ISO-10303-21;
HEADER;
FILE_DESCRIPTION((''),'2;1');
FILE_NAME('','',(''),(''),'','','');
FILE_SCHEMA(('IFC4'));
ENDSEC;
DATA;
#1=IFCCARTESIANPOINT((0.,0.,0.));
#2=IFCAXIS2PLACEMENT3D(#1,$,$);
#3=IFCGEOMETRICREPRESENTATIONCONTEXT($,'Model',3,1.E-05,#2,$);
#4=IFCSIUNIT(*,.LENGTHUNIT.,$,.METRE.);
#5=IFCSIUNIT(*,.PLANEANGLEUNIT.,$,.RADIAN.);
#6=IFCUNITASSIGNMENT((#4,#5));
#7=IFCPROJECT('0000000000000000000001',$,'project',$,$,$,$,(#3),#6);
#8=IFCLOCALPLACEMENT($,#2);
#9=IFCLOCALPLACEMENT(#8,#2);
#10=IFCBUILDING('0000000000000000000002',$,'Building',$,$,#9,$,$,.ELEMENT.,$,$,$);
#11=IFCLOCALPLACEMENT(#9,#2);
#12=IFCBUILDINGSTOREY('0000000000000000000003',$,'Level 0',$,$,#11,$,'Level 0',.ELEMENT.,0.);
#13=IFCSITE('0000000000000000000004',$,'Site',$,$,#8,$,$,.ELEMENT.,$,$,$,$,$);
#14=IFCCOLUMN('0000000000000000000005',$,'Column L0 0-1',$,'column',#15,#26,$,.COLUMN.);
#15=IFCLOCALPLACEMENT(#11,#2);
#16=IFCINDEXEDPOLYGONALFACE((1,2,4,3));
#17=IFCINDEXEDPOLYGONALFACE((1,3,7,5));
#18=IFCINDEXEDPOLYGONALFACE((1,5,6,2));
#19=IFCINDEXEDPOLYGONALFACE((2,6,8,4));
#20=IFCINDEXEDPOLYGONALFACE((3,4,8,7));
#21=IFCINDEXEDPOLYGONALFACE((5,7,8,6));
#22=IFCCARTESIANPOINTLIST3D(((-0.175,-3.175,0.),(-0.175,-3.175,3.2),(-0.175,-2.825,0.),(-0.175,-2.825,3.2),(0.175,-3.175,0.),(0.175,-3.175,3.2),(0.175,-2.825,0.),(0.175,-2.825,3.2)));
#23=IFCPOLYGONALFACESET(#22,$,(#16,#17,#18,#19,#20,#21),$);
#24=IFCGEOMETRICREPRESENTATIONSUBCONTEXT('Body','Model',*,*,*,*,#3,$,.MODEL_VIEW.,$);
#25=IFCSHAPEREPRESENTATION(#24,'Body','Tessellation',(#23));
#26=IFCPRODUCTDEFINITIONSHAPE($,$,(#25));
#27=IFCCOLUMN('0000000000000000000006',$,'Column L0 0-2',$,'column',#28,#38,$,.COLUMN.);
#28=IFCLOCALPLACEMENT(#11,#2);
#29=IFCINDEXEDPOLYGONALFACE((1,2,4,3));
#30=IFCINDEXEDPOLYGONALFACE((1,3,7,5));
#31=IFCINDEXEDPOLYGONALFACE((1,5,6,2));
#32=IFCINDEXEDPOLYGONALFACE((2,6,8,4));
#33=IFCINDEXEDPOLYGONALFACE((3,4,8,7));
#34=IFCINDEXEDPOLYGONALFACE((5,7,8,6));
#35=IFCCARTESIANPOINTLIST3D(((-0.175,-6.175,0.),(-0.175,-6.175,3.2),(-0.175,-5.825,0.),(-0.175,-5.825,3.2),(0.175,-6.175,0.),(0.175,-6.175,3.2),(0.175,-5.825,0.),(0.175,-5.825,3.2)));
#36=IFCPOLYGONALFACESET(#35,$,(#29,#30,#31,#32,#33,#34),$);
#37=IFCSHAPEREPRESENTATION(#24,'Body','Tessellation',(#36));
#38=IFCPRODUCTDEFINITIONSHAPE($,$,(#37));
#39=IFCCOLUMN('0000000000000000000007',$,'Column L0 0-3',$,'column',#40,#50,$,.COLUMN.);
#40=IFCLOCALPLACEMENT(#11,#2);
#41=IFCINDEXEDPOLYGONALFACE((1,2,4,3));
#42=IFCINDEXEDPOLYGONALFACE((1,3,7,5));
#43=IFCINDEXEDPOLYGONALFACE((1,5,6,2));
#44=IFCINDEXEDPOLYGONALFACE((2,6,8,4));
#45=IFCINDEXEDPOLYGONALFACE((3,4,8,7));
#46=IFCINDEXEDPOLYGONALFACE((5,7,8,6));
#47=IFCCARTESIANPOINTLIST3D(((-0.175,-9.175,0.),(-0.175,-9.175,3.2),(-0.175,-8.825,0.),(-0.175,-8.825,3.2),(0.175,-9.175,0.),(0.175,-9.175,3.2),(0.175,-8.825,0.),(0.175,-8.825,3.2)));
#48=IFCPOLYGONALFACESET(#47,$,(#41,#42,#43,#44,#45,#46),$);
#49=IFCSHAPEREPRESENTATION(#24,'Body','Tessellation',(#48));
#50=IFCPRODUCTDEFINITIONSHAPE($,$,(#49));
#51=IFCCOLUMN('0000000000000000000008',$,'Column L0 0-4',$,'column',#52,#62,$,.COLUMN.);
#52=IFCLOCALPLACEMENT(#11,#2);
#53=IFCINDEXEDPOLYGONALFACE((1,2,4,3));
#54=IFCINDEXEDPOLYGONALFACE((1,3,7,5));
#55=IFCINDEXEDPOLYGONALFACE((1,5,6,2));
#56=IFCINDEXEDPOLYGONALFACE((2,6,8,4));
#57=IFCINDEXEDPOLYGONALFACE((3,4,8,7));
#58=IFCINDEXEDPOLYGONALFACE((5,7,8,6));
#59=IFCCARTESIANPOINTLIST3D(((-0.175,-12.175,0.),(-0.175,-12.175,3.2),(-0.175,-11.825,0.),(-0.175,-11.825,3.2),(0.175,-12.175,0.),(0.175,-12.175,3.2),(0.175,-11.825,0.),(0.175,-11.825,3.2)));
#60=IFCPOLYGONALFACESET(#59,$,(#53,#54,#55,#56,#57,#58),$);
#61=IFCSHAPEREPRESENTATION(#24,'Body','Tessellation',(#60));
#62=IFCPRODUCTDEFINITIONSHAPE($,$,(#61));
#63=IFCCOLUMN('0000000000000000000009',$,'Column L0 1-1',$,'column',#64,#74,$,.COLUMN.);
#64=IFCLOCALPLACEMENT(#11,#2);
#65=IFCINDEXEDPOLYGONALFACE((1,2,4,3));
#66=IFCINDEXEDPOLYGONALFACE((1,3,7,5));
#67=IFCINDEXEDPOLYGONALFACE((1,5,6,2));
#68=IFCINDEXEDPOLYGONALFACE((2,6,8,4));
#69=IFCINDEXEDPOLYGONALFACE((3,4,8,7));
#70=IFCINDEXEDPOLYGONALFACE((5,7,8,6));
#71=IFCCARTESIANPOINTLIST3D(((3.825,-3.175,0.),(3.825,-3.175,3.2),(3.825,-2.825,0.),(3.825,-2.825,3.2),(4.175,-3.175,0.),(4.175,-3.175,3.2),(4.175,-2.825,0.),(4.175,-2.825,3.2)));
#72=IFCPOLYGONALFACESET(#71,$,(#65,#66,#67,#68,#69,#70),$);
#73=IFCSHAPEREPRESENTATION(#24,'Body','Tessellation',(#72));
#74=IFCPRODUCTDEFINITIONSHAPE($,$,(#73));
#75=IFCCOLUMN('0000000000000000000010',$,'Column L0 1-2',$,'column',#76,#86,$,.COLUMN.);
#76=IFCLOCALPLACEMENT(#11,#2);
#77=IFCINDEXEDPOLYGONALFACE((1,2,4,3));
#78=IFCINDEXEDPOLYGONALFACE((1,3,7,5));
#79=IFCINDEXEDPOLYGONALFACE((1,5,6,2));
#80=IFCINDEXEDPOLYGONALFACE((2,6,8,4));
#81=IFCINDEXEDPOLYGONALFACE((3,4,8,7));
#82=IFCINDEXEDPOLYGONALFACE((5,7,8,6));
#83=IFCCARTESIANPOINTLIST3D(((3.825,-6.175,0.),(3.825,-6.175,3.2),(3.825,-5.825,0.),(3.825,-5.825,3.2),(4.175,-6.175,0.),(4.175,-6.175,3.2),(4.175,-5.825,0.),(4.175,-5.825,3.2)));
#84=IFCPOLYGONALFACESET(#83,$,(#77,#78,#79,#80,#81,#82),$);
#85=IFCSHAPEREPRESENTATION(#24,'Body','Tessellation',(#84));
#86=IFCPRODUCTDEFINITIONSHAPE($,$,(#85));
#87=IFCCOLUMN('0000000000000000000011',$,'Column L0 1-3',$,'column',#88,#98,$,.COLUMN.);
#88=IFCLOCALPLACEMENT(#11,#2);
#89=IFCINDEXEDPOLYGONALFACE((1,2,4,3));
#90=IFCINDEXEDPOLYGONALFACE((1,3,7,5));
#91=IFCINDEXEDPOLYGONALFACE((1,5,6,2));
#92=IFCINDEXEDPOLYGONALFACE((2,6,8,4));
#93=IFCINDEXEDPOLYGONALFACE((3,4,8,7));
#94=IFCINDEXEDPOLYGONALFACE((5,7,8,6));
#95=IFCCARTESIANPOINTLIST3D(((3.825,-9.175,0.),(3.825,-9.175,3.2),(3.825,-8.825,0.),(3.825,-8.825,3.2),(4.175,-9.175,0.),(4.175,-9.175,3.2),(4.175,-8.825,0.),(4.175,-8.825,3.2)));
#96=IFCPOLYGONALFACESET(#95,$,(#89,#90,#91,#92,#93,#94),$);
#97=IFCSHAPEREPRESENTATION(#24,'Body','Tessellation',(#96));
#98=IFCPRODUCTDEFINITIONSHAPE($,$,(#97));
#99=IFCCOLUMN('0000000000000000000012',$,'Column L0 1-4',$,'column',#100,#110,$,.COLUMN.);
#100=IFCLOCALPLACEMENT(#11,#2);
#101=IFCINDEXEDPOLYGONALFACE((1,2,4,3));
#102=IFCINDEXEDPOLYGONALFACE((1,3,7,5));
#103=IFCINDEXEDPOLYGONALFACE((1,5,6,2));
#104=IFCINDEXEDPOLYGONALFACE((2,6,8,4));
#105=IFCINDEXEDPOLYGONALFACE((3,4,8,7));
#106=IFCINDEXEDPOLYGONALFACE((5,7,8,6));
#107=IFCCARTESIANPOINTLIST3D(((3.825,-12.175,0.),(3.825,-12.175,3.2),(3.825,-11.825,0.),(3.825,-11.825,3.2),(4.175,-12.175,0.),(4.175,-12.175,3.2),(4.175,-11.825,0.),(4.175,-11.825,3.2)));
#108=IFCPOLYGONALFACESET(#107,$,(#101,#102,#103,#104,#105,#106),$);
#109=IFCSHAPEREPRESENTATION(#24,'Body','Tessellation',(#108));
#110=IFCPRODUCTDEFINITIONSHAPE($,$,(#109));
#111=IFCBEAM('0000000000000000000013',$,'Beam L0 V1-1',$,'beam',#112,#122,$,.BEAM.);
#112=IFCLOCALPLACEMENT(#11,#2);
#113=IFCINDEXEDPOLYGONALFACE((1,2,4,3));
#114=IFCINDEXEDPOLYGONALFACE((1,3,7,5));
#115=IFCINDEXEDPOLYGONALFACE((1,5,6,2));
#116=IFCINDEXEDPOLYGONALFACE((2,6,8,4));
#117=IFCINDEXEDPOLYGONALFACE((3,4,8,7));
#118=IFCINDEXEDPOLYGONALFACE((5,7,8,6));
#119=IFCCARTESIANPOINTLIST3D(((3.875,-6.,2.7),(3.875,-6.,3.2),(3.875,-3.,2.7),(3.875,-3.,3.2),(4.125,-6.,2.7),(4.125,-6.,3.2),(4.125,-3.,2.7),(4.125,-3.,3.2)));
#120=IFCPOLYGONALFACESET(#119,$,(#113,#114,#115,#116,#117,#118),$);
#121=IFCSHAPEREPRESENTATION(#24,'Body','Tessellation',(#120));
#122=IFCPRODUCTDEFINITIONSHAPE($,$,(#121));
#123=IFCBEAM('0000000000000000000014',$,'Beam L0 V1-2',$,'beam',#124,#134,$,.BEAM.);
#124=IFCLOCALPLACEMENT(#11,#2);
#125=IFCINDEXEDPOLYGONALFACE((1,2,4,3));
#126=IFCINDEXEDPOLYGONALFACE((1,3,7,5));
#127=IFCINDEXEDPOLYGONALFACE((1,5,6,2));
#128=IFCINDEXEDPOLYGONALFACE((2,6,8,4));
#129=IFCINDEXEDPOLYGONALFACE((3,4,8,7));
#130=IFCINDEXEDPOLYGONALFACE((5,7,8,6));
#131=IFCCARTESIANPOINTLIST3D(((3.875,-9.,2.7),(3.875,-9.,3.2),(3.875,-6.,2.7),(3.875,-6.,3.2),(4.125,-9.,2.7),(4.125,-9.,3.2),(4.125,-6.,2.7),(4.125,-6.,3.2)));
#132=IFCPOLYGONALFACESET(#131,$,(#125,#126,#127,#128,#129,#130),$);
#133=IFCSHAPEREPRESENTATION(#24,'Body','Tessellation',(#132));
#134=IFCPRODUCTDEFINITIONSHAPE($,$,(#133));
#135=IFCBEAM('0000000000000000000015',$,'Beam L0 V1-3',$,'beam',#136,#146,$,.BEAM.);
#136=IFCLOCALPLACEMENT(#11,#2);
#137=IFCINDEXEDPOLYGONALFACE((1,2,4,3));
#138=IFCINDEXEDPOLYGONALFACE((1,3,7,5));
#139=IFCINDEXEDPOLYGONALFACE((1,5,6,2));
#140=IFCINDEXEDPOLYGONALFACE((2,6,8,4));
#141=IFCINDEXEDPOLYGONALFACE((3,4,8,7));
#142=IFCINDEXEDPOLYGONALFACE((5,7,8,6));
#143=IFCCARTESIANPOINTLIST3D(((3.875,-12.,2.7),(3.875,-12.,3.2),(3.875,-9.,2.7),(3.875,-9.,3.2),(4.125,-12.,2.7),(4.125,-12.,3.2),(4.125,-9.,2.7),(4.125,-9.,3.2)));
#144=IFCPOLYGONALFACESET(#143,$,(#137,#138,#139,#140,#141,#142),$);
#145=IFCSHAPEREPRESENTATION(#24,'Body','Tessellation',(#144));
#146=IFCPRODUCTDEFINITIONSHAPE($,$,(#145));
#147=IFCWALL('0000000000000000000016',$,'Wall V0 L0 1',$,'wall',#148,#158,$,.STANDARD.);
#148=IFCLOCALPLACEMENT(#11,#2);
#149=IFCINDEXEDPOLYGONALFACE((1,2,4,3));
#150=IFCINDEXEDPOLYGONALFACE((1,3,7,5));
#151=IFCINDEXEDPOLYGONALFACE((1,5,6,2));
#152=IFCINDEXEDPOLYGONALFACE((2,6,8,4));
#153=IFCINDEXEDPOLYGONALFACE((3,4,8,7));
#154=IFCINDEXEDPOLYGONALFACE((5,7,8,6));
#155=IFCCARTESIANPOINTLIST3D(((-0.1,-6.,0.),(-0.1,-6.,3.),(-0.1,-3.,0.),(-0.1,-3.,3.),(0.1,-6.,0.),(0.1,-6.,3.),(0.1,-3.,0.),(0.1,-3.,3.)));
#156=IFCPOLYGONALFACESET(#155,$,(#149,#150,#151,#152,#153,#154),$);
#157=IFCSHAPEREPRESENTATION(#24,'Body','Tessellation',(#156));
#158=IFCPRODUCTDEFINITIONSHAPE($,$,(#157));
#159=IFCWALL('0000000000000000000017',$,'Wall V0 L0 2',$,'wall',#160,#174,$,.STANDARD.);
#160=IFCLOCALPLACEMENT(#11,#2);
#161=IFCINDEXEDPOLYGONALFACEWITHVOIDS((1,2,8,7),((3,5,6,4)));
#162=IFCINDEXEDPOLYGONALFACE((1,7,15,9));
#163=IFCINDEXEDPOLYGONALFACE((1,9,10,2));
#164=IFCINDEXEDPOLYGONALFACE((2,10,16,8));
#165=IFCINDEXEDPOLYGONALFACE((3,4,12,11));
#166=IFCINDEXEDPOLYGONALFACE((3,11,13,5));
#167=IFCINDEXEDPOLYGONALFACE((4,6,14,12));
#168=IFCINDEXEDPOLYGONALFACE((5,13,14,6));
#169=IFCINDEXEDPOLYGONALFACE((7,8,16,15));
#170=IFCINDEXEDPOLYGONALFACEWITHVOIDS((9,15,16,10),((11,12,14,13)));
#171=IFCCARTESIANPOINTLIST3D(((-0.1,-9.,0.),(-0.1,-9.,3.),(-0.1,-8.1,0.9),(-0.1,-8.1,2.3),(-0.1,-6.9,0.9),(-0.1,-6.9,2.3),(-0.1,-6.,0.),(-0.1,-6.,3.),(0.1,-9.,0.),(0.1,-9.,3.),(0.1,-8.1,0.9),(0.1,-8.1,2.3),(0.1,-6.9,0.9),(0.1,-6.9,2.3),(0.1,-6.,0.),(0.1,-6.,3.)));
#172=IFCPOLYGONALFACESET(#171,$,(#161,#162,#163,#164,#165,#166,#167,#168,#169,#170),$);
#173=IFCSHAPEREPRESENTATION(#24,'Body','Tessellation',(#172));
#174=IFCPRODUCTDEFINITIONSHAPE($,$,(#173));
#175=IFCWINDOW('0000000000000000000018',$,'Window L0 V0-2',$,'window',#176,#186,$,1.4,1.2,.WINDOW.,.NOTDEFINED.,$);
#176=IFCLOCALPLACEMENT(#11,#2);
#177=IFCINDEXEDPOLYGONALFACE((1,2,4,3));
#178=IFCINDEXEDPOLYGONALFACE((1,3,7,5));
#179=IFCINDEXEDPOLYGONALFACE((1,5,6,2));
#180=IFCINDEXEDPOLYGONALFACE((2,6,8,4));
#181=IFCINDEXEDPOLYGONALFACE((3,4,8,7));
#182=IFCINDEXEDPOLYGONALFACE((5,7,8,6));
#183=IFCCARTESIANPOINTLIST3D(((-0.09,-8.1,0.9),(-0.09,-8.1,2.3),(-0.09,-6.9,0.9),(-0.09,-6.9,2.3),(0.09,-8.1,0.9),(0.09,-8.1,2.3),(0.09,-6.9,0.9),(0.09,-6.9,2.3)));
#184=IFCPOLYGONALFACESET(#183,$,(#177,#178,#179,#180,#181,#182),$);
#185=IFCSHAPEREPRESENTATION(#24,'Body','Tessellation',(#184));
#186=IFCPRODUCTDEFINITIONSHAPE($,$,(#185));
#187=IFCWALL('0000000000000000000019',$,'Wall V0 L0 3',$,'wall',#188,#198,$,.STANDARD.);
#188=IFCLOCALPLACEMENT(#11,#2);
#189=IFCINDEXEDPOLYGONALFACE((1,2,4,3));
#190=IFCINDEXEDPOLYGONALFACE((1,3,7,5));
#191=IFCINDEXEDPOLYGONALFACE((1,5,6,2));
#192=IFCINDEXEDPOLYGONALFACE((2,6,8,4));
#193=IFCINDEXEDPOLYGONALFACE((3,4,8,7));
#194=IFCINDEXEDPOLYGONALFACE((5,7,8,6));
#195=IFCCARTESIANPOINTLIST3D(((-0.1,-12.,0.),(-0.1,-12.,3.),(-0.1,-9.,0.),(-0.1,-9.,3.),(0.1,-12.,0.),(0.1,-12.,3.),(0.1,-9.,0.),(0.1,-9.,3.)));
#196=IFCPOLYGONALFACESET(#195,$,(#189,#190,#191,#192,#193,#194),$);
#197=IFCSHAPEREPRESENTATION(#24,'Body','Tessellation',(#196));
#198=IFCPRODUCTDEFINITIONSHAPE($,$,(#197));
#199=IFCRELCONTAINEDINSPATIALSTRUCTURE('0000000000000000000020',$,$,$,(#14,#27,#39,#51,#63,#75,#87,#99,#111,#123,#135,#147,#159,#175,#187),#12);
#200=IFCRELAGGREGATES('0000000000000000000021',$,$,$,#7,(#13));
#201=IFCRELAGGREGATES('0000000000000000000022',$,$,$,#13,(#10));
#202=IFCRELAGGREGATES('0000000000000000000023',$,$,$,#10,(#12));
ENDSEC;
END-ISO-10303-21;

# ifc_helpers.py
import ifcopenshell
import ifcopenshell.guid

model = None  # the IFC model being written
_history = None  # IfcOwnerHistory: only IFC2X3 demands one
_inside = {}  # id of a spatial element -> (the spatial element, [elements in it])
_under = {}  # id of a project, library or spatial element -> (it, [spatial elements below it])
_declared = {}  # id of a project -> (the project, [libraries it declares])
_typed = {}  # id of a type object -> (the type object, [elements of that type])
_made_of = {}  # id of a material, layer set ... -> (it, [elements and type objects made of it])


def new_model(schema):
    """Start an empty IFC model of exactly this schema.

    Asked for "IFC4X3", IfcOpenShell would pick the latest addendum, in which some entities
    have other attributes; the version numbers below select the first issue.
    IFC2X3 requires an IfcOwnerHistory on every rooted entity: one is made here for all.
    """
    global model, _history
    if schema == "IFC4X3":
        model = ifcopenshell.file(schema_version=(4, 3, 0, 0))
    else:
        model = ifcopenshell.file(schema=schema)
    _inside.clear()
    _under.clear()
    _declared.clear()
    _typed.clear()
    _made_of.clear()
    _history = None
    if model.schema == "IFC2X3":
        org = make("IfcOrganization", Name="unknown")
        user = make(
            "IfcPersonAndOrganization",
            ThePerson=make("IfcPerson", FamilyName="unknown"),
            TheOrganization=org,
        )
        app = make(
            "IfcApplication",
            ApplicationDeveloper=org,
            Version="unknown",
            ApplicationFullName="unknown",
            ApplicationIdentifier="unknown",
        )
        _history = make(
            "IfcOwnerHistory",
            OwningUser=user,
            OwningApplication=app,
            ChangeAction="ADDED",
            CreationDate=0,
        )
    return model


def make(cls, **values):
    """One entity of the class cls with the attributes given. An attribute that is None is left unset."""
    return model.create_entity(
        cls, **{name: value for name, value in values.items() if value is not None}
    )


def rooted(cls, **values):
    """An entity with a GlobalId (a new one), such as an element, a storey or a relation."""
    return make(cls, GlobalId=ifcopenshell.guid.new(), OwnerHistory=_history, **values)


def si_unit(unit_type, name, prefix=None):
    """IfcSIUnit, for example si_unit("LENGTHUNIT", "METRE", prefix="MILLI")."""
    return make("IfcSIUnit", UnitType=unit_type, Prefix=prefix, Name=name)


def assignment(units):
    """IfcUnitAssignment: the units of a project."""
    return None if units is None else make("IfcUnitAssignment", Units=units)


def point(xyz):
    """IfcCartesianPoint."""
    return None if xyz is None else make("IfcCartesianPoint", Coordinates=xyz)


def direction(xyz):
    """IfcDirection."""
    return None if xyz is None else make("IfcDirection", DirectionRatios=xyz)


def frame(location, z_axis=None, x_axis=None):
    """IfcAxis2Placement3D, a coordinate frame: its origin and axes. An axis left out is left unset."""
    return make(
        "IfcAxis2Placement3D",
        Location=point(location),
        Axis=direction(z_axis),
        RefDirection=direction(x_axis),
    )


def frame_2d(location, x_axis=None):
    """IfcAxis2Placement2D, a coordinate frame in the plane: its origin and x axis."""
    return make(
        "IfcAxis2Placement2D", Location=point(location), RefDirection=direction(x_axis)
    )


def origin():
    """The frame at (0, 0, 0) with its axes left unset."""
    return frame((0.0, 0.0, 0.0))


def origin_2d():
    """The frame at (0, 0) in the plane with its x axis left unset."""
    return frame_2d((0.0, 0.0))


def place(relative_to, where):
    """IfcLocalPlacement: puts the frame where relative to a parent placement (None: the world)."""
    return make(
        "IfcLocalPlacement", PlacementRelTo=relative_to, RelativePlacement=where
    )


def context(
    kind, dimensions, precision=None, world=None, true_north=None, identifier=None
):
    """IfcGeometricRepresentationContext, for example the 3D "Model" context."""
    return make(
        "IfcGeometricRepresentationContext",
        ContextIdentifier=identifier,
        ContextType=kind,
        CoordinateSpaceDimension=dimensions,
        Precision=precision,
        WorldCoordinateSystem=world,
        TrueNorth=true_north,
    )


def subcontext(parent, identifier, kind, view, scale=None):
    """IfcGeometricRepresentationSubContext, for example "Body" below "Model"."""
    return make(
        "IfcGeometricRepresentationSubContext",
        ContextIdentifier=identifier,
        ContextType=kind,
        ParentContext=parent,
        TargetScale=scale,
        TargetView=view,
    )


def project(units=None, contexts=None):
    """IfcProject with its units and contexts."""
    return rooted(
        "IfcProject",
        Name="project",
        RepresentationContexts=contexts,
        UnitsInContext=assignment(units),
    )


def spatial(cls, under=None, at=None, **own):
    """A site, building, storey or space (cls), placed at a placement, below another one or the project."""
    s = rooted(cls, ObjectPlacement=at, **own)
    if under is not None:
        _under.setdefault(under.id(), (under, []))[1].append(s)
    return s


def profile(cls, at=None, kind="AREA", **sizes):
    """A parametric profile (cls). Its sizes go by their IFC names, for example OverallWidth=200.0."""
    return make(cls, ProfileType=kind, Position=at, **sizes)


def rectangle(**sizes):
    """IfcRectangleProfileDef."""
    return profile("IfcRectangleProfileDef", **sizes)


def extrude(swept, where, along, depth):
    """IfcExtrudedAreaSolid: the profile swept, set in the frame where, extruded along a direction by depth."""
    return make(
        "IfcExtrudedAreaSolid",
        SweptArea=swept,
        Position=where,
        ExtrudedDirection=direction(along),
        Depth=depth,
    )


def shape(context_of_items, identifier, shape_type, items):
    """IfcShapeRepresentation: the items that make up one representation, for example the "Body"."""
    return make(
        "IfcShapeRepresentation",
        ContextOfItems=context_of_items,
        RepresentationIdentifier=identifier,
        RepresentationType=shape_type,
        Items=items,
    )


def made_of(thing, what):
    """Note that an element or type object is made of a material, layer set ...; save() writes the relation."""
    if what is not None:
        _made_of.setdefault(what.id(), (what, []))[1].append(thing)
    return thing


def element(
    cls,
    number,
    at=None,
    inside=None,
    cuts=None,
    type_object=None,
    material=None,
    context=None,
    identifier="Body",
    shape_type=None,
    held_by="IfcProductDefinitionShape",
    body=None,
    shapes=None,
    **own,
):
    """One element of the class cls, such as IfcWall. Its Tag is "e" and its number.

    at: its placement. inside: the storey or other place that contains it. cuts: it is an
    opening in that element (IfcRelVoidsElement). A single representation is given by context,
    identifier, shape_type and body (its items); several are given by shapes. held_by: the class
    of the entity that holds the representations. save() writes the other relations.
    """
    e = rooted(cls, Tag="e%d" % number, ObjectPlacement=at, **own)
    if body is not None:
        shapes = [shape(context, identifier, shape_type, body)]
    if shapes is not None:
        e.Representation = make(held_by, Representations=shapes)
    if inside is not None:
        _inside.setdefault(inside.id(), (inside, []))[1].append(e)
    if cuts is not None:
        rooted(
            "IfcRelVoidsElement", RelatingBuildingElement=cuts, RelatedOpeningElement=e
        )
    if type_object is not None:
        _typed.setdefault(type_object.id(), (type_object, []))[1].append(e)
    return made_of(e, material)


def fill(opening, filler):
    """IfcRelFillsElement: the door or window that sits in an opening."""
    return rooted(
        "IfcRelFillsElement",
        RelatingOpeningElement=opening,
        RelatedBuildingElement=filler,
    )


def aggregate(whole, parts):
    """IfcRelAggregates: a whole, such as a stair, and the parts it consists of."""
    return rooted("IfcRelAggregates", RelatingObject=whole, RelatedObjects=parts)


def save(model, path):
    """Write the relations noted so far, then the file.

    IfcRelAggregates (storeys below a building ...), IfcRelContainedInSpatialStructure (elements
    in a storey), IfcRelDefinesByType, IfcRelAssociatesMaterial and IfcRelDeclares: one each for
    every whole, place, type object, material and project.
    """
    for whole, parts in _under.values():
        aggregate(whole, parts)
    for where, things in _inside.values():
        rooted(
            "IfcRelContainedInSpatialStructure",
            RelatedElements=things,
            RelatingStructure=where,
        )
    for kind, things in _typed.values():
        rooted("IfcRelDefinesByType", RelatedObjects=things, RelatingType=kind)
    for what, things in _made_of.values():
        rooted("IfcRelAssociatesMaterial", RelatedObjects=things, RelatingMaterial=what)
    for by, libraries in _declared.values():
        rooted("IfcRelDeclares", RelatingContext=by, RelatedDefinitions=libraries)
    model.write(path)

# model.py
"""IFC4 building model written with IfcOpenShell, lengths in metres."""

from ifc_helpers import new_model, si_unit, frame, frame_2d, origin, origin_2d, place, context, subcontext, project, spatial, rectangle, extrude, element, fill, save


model = new_model("IFC4")

# Units and contexts
model_context = context("Model", 3, precision=1e-05, world=origin())
body_context = subcontext(model_context, "Body", "Model", "MODEL_VIEW")
ifc_project = project(units=[si_unit("LENGTHUNIT", "METRE"), si_unit("PLANEANGLEUNIT", "RADIAN")], contexts=[model_context])

# Site, building, storey
site_placement = place(None, origin())
site = spatial("IfcSite", under=ifc_project, at=site_placement, Name="Site", CompositionType="ELEMENT")
building_placement = place(site_placement, origin())
building = spatial("IfcBuilding", under=site, at=building_placement, Name="Building", CompositionType="ELEMENT")
storey_placement = place(building_placement, origin())
storey = spatial("IfcBuildingStorey", under=building, at=storey_placement, Name="Level 0", LongName="Level 0", CompositionType="ELEMENT", Elevation=0.0)

# Columns
for number, where, name in (
    (1, (0.0, -3.0, 0.0), "Column L0 0-1"),
    (2, (0.0, -6.0, 0.0), "Column L0 0-2"),
    (3, (0.0, -9.0, 0.0), "Column L0 0-3"),
    (4, (0.0, -12.0, 0.0), "Column L0 0-4"),
    (5, (4.0, -3.0, 0.0), "Column L0 1-1"),
    (6, (4.0, -6.0, 0.0), "Column L0 1-2"),
    (7, (4.0, -9.0, 0.0), "Column L0 1-3"),
    (8, (4.0, -12.0, 0.0), "Column L0 1-4"),
):
    element("IfcColumn", number, at=place(storey_placement, frame(where)), inside=storey, Name=name, ObjectType="column", PredefinedType="COLUMN", context=body_context, shape_type="SweptSolid", body=[
        extrude(rectangle(XDim=0.35, YDim=0.35, at=origin_2d()), origin(), (0.0, 0.0, 1.0), 3.2),
    ])

# Beams
for number, where, z_axis, x_axis, name in (
    (9, (4.0, -3.0, 2.95), (0.0, -1.0, 0.0), (0.0, 0.0, 1.0), "Beam L0 V1-1"),
    (10, (4.0, -6.0, 2.95), (0.0, -1.0, 0.0), (0.0, 0.0, 1.0), "Beam L0 V1-2"),
    (11, (4.0, -9.0, 2.95), (0.0, -1.0, 0.0), (0.0, 0.0, 1.0), "Beam L0 V1-3"),
):
    element("IfcBeam", number, at=place(storey_placement, frame(where, z_axis=z_axis, x_axis=x_axis)), inside=storey, Name=name, ObjectType="beam", PredefinedType="BEAM", context=body_context, shape_type="SweptSolid", body=[
        extrude(rectangle(XDim=0.5, YDim=0.25, at=origin_2d()), origin(), (0.0, 0.0, 1.0), 3.0),
    ])

# Wall
wall_1_placement = place(storey_placement, frame((0.0, -3.0, 0.0), z_axis=(0.0, 0.0, 1.0), x_axis=(0.0, -1.0, 0.0)))
element("IfcWall", 12, at=wall_1_placement, inside=storey, Name="Wall V0 L0 1", ObjectType="wall", PredefinedType="STANDARD", context=body_context, shape_type="SweptSolid", body=[
    extrude(rectangle(XDim=3.0, YDim=0.2, at=frame_2d((1.5, 0.0))), origin(), (0.0, 0.0, 1.0), 3.0),
])

# Wall, opening, window
wall_2_placement = place(storey_placement, frame((0.0, -6.0, 0.0), z_axis=(0.0, 0.0, 1.0), x_axis=(0.0, -1.0, 0.0)))
wall_2 = element("IfcWall", 13, at=wall_2_placement, inside=storey, Name="Wall V0 L0 2", ObjectType="wall", PredefinedType="STANDARD", context=body_context, shape_type="SweptSolid", body=[
    extrude(rectangle(XDim=3.0, YDim=0.2, at=frame_2d((1.5, 0.0))), origin(), (0.0, 0.0, 1.0), 3.0),
])
opening_1_placement = place(storey_placement, frame((0.0, -7.5, 0.9), z_axis=(0.0, 0.0, 1.0), x_axis=(0.0, -1.0, 0.0)))
opening_1 = element("IfcOpeningElement", 14, at=opening_1_placement, cuts=wall_2, ObjectType="Opening", PredefinedType="OPENING", context=body_context, shape_type="SweptSolid", body=[
    extrude(rectangle(XDim=1.2, YDim=0.22, at=origin_2d()), origin(), (0.0, 0.0, 1.0), 1.4),
])
window_1_placement = place(storey_placement, frame((0.0, -7.5, 0.9), z_axis=(0.0, 0.0, 1.0), x_axis=(0.0, -1.0, 0.0)))
window_1 = element("IfcWindow", 15, at=window_1_placement, inside=storey, Name="Window L0 V0-2", ObjectType="window", OverallHeight=1.4, OverallWidth=1.2, PartitioningType="NOTDEFINED", PredefinedType="WINDOW", context=body_context, shape_type="SweptSolid", body=[
    extrude(rectangle(XDim=1.2, YDim=0.18, at=origin_2d()), origin(), (0.0, 0.0, 1.0), 1.4),
])
fill(opening_1, window_1)

# Wall
wall_3_placement = place(storey_placement, frame((0.0, -9.0, 0.0), z_axis=(0.0, 0.0, 1.0), x_axis=(0.0, -1.0, 0.0)))
element("IfcWall", 16, at=wall_3_placement, inside=storey, Name="Wall V0 L0 3", ObjectType="wall", PredefinedType="STANDARD", context=body_context, shape_type="SweptSolid", body=[
    extrude(rectangle(XDim=3.0, YDim=0.2, at=frame_2d((1.5, 0.0))), origin(), (0.0, 0.0, 1.0), 3.0),
])

save(model, "model.ifc")
